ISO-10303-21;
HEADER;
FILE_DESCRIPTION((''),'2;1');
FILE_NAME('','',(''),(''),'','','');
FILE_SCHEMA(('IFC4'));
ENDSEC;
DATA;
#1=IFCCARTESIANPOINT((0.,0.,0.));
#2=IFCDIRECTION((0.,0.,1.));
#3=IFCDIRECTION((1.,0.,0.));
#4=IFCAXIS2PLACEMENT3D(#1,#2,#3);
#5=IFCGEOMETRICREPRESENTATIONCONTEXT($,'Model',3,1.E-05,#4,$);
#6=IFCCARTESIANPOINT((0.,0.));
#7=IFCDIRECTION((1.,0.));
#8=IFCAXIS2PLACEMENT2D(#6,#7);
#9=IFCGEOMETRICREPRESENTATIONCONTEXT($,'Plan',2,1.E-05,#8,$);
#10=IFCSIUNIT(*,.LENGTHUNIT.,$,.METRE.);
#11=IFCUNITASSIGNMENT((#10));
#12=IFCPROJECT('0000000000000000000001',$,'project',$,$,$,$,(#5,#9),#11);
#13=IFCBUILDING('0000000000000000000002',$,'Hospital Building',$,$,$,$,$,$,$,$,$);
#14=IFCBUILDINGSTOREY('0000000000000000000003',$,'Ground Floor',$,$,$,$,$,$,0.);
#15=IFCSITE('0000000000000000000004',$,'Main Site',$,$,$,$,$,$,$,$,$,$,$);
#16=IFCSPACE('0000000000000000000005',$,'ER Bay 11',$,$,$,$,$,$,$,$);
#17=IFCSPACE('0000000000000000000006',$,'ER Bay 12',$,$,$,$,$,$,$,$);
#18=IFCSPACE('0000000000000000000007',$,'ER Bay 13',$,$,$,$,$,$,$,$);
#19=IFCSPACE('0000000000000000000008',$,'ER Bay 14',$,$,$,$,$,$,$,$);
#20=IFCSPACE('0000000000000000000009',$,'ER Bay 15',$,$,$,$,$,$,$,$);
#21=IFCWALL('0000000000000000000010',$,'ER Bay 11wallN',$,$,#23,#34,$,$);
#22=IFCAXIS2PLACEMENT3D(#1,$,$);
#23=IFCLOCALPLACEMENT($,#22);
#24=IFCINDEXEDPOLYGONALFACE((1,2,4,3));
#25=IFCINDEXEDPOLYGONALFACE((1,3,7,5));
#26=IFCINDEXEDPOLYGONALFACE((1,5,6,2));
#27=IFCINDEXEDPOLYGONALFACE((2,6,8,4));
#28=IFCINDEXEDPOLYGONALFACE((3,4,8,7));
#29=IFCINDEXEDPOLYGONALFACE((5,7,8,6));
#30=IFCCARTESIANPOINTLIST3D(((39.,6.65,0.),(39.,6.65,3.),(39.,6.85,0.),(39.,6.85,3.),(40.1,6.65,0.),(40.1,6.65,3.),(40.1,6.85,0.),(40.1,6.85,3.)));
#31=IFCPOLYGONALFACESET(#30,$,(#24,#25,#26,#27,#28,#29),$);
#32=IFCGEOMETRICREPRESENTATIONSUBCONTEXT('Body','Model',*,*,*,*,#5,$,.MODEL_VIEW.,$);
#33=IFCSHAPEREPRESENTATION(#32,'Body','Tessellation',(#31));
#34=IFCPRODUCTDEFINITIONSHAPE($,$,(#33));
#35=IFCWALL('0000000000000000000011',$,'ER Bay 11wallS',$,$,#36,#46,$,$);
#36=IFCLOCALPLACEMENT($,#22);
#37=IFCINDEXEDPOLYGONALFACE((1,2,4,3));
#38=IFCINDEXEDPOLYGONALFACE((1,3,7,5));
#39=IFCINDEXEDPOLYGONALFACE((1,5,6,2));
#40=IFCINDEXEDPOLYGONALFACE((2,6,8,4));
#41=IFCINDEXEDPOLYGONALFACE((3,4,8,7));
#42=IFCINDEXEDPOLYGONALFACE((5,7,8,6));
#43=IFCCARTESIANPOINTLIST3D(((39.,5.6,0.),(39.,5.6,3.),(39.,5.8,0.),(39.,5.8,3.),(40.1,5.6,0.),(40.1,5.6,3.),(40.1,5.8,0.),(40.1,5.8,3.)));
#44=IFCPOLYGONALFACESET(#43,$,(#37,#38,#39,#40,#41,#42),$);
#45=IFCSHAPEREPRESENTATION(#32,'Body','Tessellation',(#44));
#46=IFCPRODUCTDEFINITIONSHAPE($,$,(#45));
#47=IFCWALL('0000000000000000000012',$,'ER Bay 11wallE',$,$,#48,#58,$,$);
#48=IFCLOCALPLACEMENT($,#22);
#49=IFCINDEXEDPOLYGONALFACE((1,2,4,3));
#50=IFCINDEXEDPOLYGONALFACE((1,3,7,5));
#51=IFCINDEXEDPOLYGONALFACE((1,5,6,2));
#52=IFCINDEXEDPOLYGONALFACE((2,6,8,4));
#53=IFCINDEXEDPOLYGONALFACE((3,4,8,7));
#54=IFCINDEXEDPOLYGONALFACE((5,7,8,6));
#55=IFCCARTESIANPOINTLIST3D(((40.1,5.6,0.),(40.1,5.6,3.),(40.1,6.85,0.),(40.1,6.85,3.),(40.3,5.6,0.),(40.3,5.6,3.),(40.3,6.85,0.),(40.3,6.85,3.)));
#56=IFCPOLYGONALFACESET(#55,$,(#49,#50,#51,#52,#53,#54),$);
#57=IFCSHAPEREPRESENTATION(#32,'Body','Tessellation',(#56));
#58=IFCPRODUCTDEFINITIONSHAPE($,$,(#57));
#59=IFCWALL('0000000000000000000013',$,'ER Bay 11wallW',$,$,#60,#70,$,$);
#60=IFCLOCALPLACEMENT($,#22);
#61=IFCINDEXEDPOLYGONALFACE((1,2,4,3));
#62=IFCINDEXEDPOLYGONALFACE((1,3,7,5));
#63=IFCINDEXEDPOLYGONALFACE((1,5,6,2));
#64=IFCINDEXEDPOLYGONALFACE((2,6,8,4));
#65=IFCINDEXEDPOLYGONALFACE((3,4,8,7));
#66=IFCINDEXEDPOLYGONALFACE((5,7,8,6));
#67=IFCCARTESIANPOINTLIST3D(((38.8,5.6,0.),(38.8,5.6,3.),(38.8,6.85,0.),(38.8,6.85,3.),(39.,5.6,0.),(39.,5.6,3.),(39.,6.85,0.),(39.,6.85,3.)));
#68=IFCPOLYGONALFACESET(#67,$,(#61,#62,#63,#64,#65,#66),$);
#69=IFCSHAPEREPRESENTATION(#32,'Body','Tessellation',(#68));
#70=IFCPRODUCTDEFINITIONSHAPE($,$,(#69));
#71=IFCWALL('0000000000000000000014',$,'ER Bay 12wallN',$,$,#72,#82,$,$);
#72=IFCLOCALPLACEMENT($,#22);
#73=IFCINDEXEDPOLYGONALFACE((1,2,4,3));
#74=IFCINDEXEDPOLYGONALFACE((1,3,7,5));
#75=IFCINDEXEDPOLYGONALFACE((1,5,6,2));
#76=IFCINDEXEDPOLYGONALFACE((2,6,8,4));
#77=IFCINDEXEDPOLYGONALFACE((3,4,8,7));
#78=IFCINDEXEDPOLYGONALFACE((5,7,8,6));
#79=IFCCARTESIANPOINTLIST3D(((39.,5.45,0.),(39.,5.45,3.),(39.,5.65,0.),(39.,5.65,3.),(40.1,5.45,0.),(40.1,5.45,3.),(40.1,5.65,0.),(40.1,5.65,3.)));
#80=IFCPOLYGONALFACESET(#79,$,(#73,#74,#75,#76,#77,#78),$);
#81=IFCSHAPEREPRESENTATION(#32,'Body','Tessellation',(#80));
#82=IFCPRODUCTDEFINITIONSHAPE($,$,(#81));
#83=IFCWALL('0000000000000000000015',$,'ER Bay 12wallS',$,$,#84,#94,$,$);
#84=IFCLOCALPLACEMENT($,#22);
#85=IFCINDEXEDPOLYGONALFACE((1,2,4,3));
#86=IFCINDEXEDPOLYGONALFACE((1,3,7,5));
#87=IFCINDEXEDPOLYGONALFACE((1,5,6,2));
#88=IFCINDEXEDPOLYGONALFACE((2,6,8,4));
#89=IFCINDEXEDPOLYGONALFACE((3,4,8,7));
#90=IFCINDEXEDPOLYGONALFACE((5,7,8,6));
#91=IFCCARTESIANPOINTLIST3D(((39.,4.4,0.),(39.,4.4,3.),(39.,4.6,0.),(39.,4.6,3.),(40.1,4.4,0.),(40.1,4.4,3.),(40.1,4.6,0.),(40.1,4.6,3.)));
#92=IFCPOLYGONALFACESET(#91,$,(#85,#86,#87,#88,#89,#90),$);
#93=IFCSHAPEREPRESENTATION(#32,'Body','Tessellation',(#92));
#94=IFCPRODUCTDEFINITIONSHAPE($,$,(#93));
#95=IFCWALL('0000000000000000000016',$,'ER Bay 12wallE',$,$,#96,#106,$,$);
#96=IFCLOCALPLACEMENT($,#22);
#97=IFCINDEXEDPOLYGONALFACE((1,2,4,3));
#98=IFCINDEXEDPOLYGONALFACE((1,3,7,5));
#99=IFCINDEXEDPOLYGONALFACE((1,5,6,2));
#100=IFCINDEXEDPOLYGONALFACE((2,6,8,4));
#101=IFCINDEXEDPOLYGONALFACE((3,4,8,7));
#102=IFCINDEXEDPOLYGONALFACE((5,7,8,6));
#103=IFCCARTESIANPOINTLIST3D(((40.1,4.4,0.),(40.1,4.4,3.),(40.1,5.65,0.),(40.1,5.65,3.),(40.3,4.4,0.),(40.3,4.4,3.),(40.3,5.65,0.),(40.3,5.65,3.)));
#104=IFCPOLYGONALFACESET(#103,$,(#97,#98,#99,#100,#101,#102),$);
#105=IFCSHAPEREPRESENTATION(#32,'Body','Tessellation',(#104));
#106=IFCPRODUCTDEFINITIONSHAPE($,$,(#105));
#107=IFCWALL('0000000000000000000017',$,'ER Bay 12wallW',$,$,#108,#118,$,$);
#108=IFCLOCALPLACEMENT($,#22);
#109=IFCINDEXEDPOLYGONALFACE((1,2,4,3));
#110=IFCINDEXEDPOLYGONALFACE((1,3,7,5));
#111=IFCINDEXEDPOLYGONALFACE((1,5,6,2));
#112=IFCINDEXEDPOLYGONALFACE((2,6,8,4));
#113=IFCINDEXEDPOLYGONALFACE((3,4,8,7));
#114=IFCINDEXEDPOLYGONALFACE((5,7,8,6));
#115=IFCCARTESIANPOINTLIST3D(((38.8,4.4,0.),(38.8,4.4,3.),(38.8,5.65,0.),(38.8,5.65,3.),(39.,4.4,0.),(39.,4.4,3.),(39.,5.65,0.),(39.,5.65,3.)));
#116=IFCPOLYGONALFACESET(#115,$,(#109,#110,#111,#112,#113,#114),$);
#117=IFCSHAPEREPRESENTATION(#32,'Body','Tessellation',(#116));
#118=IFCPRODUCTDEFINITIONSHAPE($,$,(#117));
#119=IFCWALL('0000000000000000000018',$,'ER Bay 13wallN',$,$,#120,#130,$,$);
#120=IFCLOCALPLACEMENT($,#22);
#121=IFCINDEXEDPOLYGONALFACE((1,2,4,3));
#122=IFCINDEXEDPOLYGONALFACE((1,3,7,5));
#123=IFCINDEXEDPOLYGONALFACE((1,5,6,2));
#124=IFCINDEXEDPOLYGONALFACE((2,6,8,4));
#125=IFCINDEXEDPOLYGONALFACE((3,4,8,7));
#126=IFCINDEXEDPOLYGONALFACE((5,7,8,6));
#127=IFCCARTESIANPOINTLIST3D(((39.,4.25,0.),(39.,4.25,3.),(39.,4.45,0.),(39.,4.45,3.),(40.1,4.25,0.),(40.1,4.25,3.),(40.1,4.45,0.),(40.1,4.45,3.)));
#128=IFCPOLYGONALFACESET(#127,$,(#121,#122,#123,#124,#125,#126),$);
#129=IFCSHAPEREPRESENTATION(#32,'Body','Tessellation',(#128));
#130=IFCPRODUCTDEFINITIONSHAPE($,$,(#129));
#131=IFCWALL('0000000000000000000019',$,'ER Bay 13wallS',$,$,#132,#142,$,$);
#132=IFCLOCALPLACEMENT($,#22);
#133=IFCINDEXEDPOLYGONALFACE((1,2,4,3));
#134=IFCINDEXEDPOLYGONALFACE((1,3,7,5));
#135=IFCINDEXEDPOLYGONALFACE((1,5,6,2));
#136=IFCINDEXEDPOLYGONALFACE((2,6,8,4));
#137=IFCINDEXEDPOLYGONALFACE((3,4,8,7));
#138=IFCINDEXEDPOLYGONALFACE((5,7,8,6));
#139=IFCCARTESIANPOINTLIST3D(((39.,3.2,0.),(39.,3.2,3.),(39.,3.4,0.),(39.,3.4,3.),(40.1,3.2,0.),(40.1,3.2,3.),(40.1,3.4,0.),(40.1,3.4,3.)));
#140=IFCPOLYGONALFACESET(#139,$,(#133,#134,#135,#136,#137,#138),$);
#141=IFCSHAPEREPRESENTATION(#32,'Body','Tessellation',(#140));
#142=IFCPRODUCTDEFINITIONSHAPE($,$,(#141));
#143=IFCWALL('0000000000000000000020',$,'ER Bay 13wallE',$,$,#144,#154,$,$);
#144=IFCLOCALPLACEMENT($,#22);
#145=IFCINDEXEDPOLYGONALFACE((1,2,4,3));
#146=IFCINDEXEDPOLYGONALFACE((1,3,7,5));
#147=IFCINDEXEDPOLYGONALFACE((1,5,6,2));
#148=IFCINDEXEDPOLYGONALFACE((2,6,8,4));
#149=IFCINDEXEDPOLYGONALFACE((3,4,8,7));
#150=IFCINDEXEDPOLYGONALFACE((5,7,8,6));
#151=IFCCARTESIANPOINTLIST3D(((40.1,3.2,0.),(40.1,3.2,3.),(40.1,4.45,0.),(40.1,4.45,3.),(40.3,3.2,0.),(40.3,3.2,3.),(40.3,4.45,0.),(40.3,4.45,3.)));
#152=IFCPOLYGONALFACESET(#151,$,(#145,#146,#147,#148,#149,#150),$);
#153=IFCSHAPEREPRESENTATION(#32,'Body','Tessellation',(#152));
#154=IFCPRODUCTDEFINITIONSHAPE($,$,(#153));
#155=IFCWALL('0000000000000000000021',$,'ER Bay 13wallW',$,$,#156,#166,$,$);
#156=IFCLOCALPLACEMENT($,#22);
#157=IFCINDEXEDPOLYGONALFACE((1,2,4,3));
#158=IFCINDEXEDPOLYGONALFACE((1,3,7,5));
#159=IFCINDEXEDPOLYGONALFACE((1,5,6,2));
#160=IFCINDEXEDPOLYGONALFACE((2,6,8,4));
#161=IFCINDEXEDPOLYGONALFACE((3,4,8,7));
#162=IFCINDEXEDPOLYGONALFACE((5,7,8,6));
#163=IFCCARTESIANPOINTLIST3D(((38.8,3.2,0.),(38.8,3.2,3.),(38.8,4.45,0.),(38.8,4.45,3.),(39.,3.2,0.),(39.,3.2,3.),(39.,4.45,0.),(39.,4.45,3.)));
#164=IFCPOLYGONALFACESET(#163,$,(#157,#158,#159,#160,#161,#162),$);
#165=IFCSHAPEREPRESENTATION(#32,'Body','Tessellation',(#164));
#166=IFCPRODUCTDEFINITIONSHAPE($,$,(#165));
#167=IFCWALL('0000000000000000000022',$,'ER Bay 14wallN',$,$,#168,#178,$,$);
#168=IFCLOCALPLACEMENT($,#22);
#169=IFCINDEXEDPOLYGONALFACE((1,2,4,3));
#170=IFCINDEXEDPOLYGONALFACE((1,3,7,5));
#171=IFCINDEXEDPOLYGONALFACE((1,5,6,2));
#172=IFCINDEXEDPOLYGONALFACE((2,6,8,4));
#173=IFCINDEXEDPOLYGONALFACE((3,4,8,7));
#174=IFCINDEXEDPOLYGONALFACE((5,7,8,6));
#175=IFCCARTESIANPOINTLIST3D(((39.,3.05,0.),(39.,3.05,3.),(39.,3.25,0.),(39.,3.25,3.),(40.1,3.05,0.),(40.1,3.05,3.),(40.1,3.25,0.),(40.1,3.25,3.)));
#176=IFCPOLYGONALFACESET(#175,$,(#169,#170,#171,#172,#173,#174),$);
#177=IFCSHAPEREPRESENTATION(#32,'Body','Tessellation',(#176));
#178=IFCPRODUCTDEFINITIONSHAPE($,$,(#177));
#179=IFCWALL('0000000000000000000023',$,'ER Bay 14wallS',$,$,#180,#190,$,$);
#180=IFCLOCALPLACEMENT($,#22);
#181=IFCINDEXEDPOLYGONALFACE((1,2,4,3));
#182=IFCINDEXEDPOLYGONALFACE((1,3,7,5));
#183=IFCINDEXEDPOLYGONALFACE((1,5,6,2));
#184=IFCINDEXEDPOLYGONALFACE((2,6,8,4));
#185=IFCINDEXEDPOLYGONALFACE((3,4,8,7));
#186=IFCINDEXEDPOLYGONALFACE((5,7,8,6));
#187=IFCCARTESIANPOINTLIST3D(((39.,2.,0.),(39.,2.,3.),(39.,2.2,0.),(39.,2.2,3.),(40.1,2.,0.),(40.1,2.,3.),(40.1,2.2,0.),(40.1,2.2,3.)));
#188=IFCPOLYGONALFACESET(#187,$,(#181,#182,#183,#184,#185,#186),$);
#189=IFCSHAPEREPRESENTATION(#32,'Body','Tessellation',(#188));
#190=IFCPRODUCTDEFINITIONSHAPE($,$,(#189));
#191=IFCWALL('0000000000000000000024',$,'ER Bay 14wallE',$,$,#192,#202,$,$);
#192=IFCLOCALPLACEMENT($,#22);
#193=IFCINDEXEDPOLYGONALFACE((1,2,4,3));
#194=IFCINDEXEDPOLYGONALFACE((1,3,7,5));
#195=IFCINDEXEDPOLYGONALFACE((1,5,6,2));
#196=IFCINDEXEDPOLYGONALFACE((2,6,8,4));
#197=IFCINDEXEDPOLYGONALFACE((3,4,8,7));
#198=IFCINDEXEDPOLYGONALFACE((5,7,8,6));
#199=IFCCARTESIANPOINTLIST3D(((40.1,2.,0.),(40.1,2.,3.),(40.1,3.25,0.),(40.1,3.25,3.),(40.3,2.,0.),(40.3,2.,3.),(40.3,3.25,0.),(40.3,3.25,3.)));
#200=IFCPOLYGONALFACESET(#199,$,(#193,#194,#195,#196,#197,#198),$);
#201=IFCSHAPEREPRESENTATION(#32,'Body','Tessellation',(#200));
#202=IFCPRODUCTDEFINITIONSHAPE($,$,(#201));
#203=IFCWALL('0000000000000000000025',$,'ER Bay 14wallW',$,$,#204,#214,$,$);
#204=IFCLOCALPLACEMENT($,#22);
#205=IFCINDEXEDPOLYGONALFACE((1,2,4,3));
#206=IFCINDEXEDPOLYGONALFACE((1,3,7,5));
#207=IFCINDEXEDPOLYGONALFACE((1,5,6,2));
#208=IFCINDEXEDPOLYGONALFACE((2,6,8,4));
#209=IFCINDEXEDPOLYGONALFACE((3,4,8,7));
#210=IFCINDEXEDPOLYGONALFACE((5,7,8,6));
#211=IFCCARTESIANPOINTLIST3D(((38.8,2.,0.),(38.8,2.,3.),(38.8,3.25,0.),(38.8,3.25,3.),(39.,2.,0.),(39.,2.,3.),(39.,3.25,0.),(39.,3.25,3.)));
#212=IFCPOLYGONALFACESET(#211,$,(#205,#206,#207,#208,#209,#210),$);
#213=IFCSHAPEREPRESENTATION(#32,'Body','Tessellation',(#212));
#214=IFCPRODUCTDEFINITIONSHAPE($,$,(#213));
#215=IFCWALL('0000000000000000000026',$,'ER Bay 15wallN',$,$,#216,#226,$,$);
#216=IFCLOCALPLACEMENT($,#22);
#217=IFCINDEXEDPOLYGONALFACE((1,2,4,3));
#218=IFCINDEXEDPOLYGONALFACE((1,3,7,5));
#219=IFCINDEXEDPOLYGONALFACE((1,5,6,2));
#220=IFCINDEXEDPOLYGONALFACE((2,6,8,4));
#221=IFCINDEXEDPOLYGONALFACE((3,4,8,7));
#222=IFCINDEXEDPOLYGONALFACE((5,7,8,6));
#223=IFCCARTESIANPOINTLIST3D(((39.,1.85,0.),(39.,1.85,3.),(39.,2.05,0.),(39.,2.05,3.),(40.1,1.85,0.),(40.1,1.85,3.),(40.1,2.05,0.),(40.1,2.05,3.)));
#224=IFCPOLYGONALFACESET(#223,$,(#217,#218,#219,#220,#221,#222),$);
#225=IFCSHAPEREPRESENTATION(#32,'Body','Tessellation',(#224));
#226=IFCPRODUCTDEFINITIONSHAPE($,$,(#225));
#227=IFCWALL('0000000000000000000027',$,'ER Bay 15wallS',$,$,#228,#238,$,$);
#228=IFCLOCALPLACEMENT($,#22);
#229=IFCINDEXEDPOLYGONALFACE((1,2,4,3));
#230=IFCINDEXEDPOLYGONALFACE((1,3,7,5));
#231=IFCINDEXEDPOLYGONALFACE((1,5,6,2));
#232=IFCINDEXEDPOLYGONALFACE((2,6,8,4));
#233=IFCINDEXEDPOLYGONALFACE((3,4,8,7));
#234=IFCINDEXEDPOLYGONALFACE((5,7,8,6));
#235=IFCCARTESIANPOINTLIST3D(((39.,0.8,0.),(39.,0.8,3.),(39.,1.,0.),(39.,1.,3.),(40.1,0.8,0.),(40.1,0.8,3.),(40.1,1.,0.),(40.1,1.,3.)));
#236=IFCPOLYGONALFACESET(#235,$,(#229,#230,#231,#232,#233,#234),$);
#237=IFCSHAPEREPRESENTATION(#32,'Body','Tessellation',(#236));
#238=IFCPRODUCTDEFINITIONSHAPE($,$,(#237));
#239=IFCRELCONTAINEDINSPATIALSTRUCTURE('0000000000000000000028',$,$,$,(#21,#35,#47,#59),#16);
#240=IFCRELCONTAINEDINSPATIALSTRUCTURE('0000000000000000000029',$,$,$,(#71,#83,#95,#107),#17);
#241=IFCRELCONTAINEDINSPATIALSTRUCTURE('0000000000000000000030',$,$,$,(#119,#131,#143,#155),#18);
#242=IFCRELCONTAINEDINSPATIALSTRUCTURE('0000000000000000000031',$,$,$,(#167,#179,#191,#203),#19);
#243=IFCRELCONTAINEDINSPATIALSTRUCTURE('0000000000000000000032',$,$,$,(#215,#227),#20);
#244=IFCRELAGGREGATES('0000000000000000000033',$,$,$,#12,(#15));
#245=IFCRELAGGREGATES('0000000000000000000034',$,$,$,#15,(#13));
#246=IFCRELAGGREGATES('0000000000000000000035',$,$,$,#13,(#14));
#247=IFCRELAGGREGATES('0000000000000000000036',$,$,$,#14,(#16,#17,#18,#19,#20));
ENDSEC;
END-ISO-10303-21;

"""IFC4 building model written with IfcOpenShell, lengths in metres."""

from ifc_helpers import new_model, si_unit, frame, origin_with_axes, origin_2d_with_axis, place, context, subcontext, project, spatial, indexed_curve, outline, extrude, element, save


model = new_model("IFC4")

# Units and contexts
model_context = context("Model", 3, precision=1e-05, world=origin_with_axes())
plan_context = context("Plan", 2, precision=1e-05, world=origin_2d_with_axis())
body_context = subcontext(model_context, "Body", "Model", "MODEL_VIEW")
ifc_project = project(units=[si_unit("LENGTHUNIT", "METRE")], contexts=[model_context, plan_context])

# Site, building, storey
site = spatial("IfcSite", under=ifc_project, Name="Main Site")
building = spatial("IfcBuilding", under=site, Name="Hospital Building")
storey = spatial("IfcBuildingStorey", under=building, Name="Ground Floor", Elevation=0.0)

# Shared definitions
space_1 = spatial("IfcSpace", under=storey, Name="ER Bay 11")

# Shared definitions
space_2 = spatial("IfcSpace", under=storey, Name="ER Bay 12")

# Shared definitions
space_3 = spatial("IfcSpace", under=storey, Name="ER Bay 13")

# Shared definitions
space_4 = spatial("IfcSpace", under=storey, Name="ER Bay 14")

# Shared definitions
space_5 = spatial("IfcSpace", under=storey, Name="ER Bay 15")

# Walls
for number, where, z_axis, x_axis, name in (
    (1, (39.0, 6.65, 0.0), (0.0, 0.0, 1.0), (1.0, 0.0, 0.0), "ER Bay 11wallN"),
    (2, (39.0, 5.6, 0.0), (0.0, 0.0, 1.0), (1.0, 0.0, 0.0), "ER Bay 11wallS"),
):
    element("IfcWall", number, at=place(None, frame(where, z_axis=z_axis, x_axis=x_axis)), inside=space_1, Name=name, context=body_context, shape_type="SweptSolid", body=[
        extrude(outline(indexed_curve([(0.0, 0.0), (0.0, 0.2), (1.1, 0.2), (1.1, 0.0), (0.0, 0.0)], self_intersect=False)), origin_with_axes(), (0.0, 0.0, 1.0), 3.0),
    ])
for number, where, z_axis, x_axis, name in (
    (3, (40.3, 5.6, 0.0), (0.0, 0.0, 1.0), (0.0, 1.0, 0.0), "ER Bay 11wallE"),
    (4, (39.0, 5.6, 0.0), (0.0, 0.0, 1.0), (0.0, 1.0, 0.0), "ER Bay 11wallW"),
):
    element("IfcWall", number, at=place(None, frame(where, z_axis=z_axis, x_axis=x_axis)), inside=space_1, Name=name, context=body_context, shape_type="SweptSolid", body=[
        extrude(outline(indexed_curve([(0.0, 0.0), (0.0, 0.2), (1.25, 0.2), (1.25, 0.0), (0.0, 0.0)], self_intersect=False)), origin_with_axes(), (0.0, 0.0, 1.0), 3.0),
    ])
for number, where, z_axis, x_axis, name in (
    (5, (39.0, 5.45, 0.0), (0.0, 0.0, 1.0), (1.0, 0.0, 0.0), "ER Bay 12wallN"),
    (6, (39.0, 4.4, 0.0), (0.0, 0.0, 1.0), (1.0, 0.0, 0.0), "ER Bay 12wallS"),
):
    element("IfcWall", number, at=place(None, frame(where, z_axis=z_axis, x_axis=x_axis)), inside=space_2, Name=name, context=body_context, shape_type="SweptSolid", body=[
        extrude(outline(indexed_curve([(0.0, 0.0), (0.0, 0.2), (1.1, 0.2), (1.1, 0.0), (0.0, 0.0)], self_intersect=False)), origin_with_axes(), (0.0, 0.0, 1.0), 3.0),
    ])
for number, where, z_axis, x_axis, name in (
    (7, (40.3, 4.4, 0.0), (0.0, 0.0, 1.0), (0.0, 1.0, 0.0), "ER Bay 12wallE"),
    (8, (39.0, 4.4, 0.0), (0.0, 0.0, 1.0), (0.0, 1.0, 0.0), "ER Bay 12wallW"),
):
    element("IfcWall", number, at=place(None, frame(where, z_axis=z_axis, x_axis=x_axis)), inside=space_2, Name=name, context=body_context, shape_type="SweptSolid", body=[
        extrude(outline(indexed_curve([(0.0, 0.0), (0.0, 0.2), (1.25, 0.2), (1.25, 0.0), (0.0, 0.0)], self_intersect=False)), origin_with_axes(), (0.0, 0.0, 1.0), 3.0),
    ])
for number, where, z_axis, x_axis, name in (
    (9, (39.0, 4.25, 0.0), (0.0, 0.0, 1.0), (1.0, 0.0, 0.0), "ER Bay 13wallN"),
    (10, (39.0, 3.2, 0.0), (0.0, 0.0, 1.0), (1.0, 0.0, 0.0), "ER Bay 13wallS"),
):
    element("IfcWall", number, at=place(None, frame(where, z_axis=z_axis, x_axis=x_axis)), inside=space_3, Name=name, context=body_context, shape_type="SweptSolid", body=[
        extrude(outline(indexed_curve([(0.0, 0.0), (0.0, 0.2), (1.1, 0.2), (1.1, 0.0), (0.0, 0.0)], self_intersect=False)), origin_with_axes(), (0.0, 0.0, 1.0), 3.0),
    ])
for number, where, z_axis, x_axis, name in (
    (11, (40.3, 3.2, 0.0), (0.0, 0.0, 1.0), (0.0, 1.0, 0.0), "ER Bay 13wallE"),
    (12, (39.0, 3.2, 0.0), (0.0, 0.0, 1.0), (0.0, 1.0, 0.0), "ER Bay 13wallW"),
):
    element("IfcWall", number, at=place(None, frame(where, z_axis=z_axis, x_axis=x_axis)), inside=space_3, Name=name, context=body_context, shape_type="SweptSolid", body=[
        extrude(outline(indexed_curve([(0.0, 0.0), (0.0, 0.2), (1.25, 0.2), (1.25, 0.0), (0.0, 0.0)], self_intersect=False)), origin_with_axes(), (0.0, 0.0, 1.0), 3.0),
    ])
for number, where, z_axis, x_axis, name in (
    (13, (39.0, 3.05, 0.0), (0.0, 0.0, 1.0), (1.0, 0.0, 0.0), "ER Bay 14wallN"),
    (14, (39.0, 2.0, 0.0), (0.0, 0.0, 1.0), (1.0, 0.0, 0.0), "ER Bay 14wallS"),
):
    element("IfcWall", number, at=place(None, frame(where, z_axis=z_axis, x_axis=x_axis)), inside=space_4, Name=name, context=body_context, shape_type="SweptSolid", body=[
        extrude(outline(indexed_curve([(0.0, 0.0), (0.0, 0.2), (1.1, 0.2), (1.1, 0.0), (0.0, 0.0)], self_intersect=False)), origin_with_axes(), (0.0, 0.0, 1.0), 3.0),
    ])
for number, where, z_axis, x_axis, name in (
    (15, (40.3, 2.0, 0.0), (0.0, 0.0, 1.0), (0.0, 1.0, 0.0), "ER Bay 14wallE"),
    (16, (39.0, 2.0, 0.0), (0.0, 0.0, 1.0), (0.0, 1.0, 0.0), "ER Bay 14wallW"),
):
    element("IfcWall", number, at=place(None, frame(where, z_axis=z_axis, x_axis=x_axis)), inside=space_4, Name=name, context=body_context, shape_type="SweptSolid", body=[
        extrude(outline(indexed_curve([(0.0, 0.0), (0.0, 0.2), (1.25, 0.2), (1.25, 0.0), (0.0, 0.0)], self_intersect=False)), origin_with_axes(), (0.0, 0.0, 1.0), 3.0),
    ])
for number, where, z_axis, x_axis, name in (
    (17, (39.0, 1.85, 0.0), (0.0, 0.0, 1.0), (1.0, 0.0, 0.0), "ER Bay 15wallN"),
    (18, (39.0, 0.8, 0.0), (0.0, 0.0, 1.0), (1.0, 0.0, 0.0), "ER Bay 15wallS"),
):
    element("IfcWall", number, at=place(None, frame(where, z_axis=z_axis, x_axis=x_axis)), inside=space_5, Name=name, context=body_context, shape_type="SweptSolid", body=[
        extrude(outline(indexed_curve([(0.0, 0.0), (0.0, 0.2), (1.1, 0.2), (1.1, 0.0), (0.0, 0.0)], self_intersect=False)), origin_with_axes(), (0.0, 0.0, 1.0), 3.0),
    ])

save(model, "model.ifc")
